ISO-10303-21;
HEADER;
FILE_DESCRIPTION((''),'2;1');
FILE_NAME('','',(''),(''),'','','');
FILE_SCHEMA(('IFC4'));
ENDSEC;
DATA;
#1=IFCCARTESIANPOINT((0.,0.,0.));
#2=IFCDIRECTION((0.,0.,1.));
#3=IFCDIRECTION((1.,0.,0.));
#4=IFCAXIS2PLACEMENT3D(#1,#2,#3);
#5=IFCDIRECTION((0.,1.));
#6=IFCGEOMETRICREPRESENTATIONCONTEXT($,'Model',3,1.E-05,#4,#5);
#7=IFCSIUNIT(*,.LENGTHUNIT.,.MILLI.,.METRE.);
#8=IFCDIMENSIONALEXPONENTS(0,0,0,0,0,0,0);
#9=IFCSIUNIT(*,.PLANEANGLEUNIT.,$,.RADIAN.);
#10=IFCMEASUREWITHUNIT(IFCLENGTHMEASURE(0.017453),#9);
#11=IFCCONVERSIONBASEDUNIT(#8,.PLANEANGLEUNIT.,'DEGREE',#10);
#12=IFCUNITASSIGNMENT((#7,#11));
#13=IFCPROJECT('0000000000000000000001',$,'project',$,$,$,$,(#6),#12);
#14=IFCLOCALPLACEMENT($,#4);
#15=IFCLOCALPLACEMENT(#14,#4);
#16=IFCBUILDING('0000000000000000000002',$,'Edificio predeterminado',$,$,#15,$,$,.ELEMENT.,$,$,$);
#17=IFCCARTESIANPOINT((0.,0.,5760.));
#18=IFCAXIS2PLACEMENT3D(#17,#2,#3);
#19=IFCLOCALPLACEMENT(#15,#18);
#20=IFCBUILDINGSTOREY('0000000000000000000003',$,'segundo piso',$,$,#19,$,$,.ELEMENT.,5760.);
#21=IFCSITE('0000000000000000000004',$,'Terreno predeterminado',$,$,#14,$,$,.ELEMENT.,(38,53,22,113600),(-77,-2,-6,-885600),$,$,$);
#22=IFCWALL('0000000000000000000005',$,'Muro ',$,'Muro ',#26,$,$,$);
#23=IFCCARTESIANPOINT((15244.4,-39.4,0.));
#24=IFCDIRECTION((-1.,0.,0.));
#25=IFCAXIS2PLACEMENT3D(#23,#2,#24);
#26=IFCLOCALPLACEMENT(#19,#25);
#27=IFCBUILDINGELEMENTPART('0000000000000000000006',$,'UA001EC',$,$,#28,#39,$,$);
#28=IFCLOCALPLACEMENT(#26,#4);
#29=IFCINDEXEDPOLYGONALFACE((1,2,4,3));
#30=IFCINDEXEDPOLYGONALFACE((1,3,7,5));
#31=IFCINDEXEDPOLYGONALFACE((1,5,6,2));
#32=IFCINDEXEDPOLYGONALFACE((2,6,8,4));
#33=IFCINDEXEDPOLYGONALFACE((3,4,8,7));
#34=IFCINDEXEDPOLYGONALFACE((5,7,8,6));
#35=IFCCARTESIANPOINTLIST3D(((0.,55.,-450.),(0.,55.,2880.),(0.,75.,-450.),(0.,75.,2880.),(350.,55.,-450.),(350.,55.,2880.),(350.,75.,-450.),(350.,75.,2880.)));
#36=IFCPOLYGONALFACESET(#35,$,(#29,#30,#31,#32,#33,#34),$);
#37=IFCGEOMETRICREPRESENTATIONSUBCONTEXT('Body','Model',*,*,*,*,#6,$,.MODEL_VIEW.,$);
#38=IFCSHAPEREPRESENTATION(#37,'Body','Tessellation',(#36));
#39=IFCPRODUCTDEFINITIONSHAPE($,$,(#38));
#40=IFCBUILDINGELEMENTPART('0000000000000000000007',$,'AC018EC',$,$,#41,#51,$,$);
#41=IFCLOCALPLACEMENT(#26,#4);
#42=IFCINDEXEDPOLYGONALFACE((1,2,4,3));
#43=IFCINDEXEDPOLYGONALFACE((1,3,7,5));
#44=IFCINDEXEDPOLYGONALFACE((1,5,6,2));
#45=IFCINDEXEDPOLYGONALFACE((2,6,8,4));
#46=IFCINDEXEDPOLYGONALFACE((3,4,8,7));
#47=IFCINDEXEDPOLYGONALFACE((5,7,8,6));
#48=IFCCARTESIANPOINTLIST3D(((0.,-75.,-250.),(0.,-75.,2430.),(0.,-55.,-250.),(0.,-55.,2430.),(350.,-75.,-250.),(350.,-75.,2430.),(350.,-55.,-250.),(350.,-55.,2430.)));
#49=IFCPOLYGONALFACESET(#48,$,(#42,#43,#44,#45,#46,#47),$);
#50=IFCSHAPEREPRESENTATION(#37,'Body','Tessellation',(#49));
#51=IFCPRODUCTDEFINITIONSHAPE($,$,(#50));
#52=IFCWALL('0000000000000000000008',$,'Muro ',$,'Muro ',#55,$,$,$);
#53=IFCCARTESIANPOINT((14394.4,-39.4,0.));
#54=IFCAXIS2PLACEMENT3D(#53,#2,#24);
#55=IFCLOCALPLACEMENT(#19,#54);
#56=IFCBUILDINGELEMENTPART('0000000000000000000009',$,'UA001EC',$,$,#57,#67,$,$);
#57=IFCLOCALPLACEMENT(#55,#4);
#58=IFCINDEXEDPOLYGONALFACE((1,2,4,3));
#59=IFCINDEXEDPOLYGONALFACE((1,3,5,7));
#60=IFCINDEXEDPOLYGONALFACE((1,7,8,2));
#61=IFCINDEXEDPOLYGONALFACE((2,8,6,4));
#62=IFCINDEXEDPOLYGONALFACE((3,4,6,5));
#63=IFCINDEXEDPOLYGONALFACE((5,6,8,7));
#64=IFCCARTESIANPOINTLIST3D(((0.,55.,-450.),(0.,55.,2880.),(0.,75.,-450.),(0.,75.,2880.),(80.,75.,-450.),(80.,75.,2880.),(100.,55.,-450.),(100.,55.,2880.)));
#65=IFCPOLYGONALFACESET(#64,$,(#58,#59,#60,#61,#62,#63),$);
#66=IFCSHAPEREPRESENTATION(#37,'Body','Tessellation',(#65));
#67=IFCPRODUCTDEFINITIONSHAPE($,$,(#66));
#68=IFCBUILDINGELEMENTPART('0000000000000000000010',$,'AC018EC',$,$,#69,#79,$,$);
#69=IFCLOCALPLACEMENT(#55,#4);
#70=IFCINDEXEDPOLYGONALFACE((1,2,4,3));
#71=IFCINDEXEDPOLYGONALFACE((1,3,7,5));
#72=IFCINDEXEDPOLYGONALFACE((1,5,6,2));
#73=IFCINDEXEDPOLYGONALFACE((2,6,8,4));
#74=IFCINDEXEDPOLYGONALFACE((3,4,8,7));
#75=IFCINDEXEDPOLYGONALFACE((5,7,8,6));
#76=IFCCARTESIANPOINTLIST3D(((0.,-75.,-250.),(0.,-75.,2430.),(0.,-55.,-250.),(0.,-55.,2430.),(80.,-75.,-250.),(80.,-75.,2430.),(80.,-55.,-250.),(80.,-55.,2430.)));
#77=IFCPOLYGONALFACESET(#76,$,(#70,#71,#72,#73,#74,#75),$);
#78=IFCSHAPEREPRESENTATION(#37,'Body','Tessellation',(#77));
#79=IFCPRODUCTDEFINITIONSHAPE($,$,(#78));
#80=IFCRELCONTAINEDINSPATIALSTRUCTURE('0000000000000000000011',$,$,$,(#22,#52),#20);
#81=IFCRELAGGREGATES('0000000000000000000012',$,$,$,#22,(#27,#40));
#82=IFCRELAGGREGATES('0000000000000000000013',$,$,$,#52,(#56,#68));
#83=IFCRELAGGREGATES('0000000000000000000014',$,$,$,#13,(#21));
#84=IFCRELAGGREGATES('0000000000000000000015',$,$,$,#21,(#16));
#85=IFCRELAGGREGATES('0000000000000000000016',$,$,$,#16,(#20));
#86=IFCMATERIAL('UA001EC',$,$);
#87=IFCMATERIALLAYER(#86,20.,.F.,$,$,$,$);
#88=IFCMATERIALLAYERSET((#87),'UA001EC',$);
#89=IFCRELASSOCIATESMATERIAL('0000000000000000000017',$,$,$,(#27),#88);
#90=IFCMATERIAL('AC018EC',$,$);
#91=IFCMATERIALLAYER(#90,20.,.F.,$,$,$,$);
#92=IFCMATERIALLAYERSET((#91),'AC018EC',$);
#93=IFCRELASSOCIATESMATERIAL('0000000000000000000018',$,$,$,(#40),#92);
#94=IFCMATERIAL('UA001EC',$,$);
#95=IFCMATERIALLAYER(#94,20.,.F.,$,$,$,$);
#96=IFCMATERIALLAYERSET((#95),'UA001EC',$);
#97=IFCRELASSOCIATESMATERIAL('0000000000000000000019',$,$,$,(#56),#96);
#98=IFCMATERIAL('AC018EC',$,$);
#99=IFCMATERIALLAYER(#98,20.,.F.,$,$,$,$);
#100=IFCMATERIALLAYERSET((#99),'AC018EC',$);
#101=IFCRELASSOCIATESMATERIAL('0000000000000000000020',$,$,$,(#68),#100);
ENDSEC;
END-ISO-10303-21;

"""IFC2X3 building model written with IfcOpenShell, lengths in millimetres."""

from ifc_helpers import new_model, entity, si_unit, converted_unit, direction, frame, origin_with_axes, place, context, subcontext, project, spatial, polyline, outline, extrude, material, layer, layer_set, layer_usage, element, aggregate, save


model = new_model("IFC2X3")

# Units and contexts
model_context = context("Model", 3, precision=1e-05, world=origin_with_axes(), true_north=direction((0.0, 1.0)))
body_context = subcontext(model_context, "Body", "Model", "MODEL_VIEW")
ifc_project = project(units=[si_unit("LENGTHUNIT", "METRE", prefix="MILLI"), converted_unit("PLANEANGLEUNIT", "DEGREE", entity("IfcLengthMeasure", 0.017453), si_unit("PLANEANGLEUNIT", "RADIAN"), dimensions=[0, 0, 0, 0, 0, 0, 0])], contexts=[model_context])

# Site, building, storey
site_placement = place(None, origin_with_axes())
site = spatial("IfcSite", under=ifc_project, at=site_placement, Name="Terreno predeterminado", CompositionType="ELEMENT", RefLatitude=(38, 53, 22, 113600), RefLongitude=(-77, -2, -6, -885600))
building_placement = place(site_placement, origin_with_axes())
building = spatial("IfcBuilding", under=site, at=building_placement, Name="Edificio predeterminado", CompositionType="ELEMENT")
storey_placement = place(building_placement, frame((0.0, 0.0, 5760.0), z_axis=(0.0, 0.0, 1.0), x_axis=(1.0, 0.0, 0.0)))
storey = spatial("IfcBuildingStorey", under=building, at=storey_placement, Name="segundo piso", CompositionType="ELEMENT", Elevation=5760.0)

# Walls, building element parts
wall_1_placement = place(storey_placement, frame((15244.4, -39.4, 0.0), z_axis=(0.0, 0.0, 1.0), x_axis=(-1.0, 0.0, 0.0)))
wall_1 = element("IfcWall", 1, at=wall_1_placement, inside=storey, Name="Muro ", ObjectType="Muro ")
ifc_material_1 = material(Name="UA001EC")
ifc_layer_1 = layer(ifc_material_1, 20.0, ventilated=False)
ifc_layer_set_1 = layer_set([ifc_layer_1], Name="UA001EC")
ifc_layer_usage_1 = layer_usage(ifc_layer_set_1, "AXIS2", "NEGATIVE", -75.0)
building_element_part_1_placement = place(wall_1_placement, origin_with_axes())
building_element_part_1 = element("IfcBuildingElementPart", 2, at=building_element_part_1_placement, material=ifc_layer_usage_1, Name="UA001EC", context=body_context, shape_type="SweptSolid", body=[
    extrude(outline(polyline([(350.0, 75.0), (350.0, 55.0), (0.0, 55.0), (0.0, 75.0), (350.0, 75.0)])), frame((0.0, 0.0, -450.0), z_axis=(0.0, 0.0, 1.0), x_axis=(1.0, 0.0, 0.0)), (0.0, 0.0, 1.0), 3330.0),
])
ifc_material_2 = material(Name="AC018EC")
ifc_layer_2 = layer(ifc_material_2, 20.0, ventilated=False)
ifc_layer_set_2 = layer_set([ifc_layer_2], Name="AC018EC")
ifc_layer_usage_2 = layer_usage(ifc_layer_set_2, "AXIS2", "NEGATIVE", 55.0)
building_element_part_2_placement = place(wall_1_placement, origin_with_axes())
building_element_part_2 = element("IfcBuildingElementPart", 3, at=building_element_part_2_placement, material=ifc_layer_usage_2, Name="AC018EC", context=body_context, shape_type="SweptSolid", body=[
    extrude(outline(polyline([(350.0, -55.0), (350.0, -75.0), (0.0, -75.0), (0.0, -55.0), (350.0, -55.0)])), frame((0.0, 0.0, -250.0), z_axis=(0.0, 0.0, 1.0), x_axis=(1.0, 0.0, 0.0)), (0.0, 0.0, 1.0), 2680.0),
])
aggregate(wall_1, [building_element_part_1, building_element_part_2])
wall_2_placement = place(storey_placement, frame((14394.4, -39.4, 0.0), z_axis=(0.0, 0.0, 1.0), x_axis=(-1.0, 0.0, 0.0)))
wall_2 = element("IfcWall", 4, at=wall_2_placement, inside=storey, Name="Muro ", ObjectType="Muro ")
ifc_material_3 = material(Name="UA001EC")
ifc_layer_3 = layer(ifc_material_3, 20.0, ventilated=False)
ifc_layer_set_3 = layer_set([ifc_layer_3], Name="UA001EC")
ifc_layer_usage_3 = layer_usage(ifc_layer_set_3, "AXIS2", "NEGATIVE", -75.0)
building_element_part_3_placement = place(wall_2_placement, origin_with_axes())
building_element_part_3 = element("IfcBuildingElementPart", 5, at=building_element_part_3_placement, material=ifc_layer_usage_3, Name="UA001EC", context=body_context, shape_type="SweptSolid", body=[
    extrude(outline(polyline([(80.0, 75.0), (100.0, 55.0), (0.0, 55.0), (0.0, 75.0), (80.0, 75.0)])), frame((0.0, 0.0, -450.0), z_axis=(0.0, 0.0, 1.0), x_axis=(1.0, 0.0, 0.0)), (0.0, 0.0, 1.0), 3330.0),
])
ifc_material_4 = material(Name="AC018EC")
ifc_layer_4 = layer(ifc_material_4, 20.0, ventilated=False)
ifc_layer_set_4 = layer_set([ifc_layer_4], Name="AC018EC")
ifc_layer_usage_4 = layer_usage(ifc_layer_set_4, "AXIS2", "NEGATIVE", 55.0)
building_element_part_4_placement = place(wall_2_placement, origin_with_axes())
building_element_part_4 = element("IfcBuildingElementPart", 6, at=building_element_part_4_placement, material=ifc_layer_usage_4, Name="AC018EC", context=body_context, shape_type="SweptSolid", body=[
    extrude(outline(polyline([(80.0, -55.0), (80.0, -75.0), (0.0, -75.0), (0.0, -55.0), (80.0, -55.0)])), frame((0.0, 0.0, -250.0), z_axis=(0.0, 0.0, 1.0), x_axis=(1.0, 0.0, 0.0)), (0.0, 0.0, 1.0), 2680.0),
])
aggregate(wall_2, [building_element_part_3, building_element_part_4])

save(model, "model.ifc")
